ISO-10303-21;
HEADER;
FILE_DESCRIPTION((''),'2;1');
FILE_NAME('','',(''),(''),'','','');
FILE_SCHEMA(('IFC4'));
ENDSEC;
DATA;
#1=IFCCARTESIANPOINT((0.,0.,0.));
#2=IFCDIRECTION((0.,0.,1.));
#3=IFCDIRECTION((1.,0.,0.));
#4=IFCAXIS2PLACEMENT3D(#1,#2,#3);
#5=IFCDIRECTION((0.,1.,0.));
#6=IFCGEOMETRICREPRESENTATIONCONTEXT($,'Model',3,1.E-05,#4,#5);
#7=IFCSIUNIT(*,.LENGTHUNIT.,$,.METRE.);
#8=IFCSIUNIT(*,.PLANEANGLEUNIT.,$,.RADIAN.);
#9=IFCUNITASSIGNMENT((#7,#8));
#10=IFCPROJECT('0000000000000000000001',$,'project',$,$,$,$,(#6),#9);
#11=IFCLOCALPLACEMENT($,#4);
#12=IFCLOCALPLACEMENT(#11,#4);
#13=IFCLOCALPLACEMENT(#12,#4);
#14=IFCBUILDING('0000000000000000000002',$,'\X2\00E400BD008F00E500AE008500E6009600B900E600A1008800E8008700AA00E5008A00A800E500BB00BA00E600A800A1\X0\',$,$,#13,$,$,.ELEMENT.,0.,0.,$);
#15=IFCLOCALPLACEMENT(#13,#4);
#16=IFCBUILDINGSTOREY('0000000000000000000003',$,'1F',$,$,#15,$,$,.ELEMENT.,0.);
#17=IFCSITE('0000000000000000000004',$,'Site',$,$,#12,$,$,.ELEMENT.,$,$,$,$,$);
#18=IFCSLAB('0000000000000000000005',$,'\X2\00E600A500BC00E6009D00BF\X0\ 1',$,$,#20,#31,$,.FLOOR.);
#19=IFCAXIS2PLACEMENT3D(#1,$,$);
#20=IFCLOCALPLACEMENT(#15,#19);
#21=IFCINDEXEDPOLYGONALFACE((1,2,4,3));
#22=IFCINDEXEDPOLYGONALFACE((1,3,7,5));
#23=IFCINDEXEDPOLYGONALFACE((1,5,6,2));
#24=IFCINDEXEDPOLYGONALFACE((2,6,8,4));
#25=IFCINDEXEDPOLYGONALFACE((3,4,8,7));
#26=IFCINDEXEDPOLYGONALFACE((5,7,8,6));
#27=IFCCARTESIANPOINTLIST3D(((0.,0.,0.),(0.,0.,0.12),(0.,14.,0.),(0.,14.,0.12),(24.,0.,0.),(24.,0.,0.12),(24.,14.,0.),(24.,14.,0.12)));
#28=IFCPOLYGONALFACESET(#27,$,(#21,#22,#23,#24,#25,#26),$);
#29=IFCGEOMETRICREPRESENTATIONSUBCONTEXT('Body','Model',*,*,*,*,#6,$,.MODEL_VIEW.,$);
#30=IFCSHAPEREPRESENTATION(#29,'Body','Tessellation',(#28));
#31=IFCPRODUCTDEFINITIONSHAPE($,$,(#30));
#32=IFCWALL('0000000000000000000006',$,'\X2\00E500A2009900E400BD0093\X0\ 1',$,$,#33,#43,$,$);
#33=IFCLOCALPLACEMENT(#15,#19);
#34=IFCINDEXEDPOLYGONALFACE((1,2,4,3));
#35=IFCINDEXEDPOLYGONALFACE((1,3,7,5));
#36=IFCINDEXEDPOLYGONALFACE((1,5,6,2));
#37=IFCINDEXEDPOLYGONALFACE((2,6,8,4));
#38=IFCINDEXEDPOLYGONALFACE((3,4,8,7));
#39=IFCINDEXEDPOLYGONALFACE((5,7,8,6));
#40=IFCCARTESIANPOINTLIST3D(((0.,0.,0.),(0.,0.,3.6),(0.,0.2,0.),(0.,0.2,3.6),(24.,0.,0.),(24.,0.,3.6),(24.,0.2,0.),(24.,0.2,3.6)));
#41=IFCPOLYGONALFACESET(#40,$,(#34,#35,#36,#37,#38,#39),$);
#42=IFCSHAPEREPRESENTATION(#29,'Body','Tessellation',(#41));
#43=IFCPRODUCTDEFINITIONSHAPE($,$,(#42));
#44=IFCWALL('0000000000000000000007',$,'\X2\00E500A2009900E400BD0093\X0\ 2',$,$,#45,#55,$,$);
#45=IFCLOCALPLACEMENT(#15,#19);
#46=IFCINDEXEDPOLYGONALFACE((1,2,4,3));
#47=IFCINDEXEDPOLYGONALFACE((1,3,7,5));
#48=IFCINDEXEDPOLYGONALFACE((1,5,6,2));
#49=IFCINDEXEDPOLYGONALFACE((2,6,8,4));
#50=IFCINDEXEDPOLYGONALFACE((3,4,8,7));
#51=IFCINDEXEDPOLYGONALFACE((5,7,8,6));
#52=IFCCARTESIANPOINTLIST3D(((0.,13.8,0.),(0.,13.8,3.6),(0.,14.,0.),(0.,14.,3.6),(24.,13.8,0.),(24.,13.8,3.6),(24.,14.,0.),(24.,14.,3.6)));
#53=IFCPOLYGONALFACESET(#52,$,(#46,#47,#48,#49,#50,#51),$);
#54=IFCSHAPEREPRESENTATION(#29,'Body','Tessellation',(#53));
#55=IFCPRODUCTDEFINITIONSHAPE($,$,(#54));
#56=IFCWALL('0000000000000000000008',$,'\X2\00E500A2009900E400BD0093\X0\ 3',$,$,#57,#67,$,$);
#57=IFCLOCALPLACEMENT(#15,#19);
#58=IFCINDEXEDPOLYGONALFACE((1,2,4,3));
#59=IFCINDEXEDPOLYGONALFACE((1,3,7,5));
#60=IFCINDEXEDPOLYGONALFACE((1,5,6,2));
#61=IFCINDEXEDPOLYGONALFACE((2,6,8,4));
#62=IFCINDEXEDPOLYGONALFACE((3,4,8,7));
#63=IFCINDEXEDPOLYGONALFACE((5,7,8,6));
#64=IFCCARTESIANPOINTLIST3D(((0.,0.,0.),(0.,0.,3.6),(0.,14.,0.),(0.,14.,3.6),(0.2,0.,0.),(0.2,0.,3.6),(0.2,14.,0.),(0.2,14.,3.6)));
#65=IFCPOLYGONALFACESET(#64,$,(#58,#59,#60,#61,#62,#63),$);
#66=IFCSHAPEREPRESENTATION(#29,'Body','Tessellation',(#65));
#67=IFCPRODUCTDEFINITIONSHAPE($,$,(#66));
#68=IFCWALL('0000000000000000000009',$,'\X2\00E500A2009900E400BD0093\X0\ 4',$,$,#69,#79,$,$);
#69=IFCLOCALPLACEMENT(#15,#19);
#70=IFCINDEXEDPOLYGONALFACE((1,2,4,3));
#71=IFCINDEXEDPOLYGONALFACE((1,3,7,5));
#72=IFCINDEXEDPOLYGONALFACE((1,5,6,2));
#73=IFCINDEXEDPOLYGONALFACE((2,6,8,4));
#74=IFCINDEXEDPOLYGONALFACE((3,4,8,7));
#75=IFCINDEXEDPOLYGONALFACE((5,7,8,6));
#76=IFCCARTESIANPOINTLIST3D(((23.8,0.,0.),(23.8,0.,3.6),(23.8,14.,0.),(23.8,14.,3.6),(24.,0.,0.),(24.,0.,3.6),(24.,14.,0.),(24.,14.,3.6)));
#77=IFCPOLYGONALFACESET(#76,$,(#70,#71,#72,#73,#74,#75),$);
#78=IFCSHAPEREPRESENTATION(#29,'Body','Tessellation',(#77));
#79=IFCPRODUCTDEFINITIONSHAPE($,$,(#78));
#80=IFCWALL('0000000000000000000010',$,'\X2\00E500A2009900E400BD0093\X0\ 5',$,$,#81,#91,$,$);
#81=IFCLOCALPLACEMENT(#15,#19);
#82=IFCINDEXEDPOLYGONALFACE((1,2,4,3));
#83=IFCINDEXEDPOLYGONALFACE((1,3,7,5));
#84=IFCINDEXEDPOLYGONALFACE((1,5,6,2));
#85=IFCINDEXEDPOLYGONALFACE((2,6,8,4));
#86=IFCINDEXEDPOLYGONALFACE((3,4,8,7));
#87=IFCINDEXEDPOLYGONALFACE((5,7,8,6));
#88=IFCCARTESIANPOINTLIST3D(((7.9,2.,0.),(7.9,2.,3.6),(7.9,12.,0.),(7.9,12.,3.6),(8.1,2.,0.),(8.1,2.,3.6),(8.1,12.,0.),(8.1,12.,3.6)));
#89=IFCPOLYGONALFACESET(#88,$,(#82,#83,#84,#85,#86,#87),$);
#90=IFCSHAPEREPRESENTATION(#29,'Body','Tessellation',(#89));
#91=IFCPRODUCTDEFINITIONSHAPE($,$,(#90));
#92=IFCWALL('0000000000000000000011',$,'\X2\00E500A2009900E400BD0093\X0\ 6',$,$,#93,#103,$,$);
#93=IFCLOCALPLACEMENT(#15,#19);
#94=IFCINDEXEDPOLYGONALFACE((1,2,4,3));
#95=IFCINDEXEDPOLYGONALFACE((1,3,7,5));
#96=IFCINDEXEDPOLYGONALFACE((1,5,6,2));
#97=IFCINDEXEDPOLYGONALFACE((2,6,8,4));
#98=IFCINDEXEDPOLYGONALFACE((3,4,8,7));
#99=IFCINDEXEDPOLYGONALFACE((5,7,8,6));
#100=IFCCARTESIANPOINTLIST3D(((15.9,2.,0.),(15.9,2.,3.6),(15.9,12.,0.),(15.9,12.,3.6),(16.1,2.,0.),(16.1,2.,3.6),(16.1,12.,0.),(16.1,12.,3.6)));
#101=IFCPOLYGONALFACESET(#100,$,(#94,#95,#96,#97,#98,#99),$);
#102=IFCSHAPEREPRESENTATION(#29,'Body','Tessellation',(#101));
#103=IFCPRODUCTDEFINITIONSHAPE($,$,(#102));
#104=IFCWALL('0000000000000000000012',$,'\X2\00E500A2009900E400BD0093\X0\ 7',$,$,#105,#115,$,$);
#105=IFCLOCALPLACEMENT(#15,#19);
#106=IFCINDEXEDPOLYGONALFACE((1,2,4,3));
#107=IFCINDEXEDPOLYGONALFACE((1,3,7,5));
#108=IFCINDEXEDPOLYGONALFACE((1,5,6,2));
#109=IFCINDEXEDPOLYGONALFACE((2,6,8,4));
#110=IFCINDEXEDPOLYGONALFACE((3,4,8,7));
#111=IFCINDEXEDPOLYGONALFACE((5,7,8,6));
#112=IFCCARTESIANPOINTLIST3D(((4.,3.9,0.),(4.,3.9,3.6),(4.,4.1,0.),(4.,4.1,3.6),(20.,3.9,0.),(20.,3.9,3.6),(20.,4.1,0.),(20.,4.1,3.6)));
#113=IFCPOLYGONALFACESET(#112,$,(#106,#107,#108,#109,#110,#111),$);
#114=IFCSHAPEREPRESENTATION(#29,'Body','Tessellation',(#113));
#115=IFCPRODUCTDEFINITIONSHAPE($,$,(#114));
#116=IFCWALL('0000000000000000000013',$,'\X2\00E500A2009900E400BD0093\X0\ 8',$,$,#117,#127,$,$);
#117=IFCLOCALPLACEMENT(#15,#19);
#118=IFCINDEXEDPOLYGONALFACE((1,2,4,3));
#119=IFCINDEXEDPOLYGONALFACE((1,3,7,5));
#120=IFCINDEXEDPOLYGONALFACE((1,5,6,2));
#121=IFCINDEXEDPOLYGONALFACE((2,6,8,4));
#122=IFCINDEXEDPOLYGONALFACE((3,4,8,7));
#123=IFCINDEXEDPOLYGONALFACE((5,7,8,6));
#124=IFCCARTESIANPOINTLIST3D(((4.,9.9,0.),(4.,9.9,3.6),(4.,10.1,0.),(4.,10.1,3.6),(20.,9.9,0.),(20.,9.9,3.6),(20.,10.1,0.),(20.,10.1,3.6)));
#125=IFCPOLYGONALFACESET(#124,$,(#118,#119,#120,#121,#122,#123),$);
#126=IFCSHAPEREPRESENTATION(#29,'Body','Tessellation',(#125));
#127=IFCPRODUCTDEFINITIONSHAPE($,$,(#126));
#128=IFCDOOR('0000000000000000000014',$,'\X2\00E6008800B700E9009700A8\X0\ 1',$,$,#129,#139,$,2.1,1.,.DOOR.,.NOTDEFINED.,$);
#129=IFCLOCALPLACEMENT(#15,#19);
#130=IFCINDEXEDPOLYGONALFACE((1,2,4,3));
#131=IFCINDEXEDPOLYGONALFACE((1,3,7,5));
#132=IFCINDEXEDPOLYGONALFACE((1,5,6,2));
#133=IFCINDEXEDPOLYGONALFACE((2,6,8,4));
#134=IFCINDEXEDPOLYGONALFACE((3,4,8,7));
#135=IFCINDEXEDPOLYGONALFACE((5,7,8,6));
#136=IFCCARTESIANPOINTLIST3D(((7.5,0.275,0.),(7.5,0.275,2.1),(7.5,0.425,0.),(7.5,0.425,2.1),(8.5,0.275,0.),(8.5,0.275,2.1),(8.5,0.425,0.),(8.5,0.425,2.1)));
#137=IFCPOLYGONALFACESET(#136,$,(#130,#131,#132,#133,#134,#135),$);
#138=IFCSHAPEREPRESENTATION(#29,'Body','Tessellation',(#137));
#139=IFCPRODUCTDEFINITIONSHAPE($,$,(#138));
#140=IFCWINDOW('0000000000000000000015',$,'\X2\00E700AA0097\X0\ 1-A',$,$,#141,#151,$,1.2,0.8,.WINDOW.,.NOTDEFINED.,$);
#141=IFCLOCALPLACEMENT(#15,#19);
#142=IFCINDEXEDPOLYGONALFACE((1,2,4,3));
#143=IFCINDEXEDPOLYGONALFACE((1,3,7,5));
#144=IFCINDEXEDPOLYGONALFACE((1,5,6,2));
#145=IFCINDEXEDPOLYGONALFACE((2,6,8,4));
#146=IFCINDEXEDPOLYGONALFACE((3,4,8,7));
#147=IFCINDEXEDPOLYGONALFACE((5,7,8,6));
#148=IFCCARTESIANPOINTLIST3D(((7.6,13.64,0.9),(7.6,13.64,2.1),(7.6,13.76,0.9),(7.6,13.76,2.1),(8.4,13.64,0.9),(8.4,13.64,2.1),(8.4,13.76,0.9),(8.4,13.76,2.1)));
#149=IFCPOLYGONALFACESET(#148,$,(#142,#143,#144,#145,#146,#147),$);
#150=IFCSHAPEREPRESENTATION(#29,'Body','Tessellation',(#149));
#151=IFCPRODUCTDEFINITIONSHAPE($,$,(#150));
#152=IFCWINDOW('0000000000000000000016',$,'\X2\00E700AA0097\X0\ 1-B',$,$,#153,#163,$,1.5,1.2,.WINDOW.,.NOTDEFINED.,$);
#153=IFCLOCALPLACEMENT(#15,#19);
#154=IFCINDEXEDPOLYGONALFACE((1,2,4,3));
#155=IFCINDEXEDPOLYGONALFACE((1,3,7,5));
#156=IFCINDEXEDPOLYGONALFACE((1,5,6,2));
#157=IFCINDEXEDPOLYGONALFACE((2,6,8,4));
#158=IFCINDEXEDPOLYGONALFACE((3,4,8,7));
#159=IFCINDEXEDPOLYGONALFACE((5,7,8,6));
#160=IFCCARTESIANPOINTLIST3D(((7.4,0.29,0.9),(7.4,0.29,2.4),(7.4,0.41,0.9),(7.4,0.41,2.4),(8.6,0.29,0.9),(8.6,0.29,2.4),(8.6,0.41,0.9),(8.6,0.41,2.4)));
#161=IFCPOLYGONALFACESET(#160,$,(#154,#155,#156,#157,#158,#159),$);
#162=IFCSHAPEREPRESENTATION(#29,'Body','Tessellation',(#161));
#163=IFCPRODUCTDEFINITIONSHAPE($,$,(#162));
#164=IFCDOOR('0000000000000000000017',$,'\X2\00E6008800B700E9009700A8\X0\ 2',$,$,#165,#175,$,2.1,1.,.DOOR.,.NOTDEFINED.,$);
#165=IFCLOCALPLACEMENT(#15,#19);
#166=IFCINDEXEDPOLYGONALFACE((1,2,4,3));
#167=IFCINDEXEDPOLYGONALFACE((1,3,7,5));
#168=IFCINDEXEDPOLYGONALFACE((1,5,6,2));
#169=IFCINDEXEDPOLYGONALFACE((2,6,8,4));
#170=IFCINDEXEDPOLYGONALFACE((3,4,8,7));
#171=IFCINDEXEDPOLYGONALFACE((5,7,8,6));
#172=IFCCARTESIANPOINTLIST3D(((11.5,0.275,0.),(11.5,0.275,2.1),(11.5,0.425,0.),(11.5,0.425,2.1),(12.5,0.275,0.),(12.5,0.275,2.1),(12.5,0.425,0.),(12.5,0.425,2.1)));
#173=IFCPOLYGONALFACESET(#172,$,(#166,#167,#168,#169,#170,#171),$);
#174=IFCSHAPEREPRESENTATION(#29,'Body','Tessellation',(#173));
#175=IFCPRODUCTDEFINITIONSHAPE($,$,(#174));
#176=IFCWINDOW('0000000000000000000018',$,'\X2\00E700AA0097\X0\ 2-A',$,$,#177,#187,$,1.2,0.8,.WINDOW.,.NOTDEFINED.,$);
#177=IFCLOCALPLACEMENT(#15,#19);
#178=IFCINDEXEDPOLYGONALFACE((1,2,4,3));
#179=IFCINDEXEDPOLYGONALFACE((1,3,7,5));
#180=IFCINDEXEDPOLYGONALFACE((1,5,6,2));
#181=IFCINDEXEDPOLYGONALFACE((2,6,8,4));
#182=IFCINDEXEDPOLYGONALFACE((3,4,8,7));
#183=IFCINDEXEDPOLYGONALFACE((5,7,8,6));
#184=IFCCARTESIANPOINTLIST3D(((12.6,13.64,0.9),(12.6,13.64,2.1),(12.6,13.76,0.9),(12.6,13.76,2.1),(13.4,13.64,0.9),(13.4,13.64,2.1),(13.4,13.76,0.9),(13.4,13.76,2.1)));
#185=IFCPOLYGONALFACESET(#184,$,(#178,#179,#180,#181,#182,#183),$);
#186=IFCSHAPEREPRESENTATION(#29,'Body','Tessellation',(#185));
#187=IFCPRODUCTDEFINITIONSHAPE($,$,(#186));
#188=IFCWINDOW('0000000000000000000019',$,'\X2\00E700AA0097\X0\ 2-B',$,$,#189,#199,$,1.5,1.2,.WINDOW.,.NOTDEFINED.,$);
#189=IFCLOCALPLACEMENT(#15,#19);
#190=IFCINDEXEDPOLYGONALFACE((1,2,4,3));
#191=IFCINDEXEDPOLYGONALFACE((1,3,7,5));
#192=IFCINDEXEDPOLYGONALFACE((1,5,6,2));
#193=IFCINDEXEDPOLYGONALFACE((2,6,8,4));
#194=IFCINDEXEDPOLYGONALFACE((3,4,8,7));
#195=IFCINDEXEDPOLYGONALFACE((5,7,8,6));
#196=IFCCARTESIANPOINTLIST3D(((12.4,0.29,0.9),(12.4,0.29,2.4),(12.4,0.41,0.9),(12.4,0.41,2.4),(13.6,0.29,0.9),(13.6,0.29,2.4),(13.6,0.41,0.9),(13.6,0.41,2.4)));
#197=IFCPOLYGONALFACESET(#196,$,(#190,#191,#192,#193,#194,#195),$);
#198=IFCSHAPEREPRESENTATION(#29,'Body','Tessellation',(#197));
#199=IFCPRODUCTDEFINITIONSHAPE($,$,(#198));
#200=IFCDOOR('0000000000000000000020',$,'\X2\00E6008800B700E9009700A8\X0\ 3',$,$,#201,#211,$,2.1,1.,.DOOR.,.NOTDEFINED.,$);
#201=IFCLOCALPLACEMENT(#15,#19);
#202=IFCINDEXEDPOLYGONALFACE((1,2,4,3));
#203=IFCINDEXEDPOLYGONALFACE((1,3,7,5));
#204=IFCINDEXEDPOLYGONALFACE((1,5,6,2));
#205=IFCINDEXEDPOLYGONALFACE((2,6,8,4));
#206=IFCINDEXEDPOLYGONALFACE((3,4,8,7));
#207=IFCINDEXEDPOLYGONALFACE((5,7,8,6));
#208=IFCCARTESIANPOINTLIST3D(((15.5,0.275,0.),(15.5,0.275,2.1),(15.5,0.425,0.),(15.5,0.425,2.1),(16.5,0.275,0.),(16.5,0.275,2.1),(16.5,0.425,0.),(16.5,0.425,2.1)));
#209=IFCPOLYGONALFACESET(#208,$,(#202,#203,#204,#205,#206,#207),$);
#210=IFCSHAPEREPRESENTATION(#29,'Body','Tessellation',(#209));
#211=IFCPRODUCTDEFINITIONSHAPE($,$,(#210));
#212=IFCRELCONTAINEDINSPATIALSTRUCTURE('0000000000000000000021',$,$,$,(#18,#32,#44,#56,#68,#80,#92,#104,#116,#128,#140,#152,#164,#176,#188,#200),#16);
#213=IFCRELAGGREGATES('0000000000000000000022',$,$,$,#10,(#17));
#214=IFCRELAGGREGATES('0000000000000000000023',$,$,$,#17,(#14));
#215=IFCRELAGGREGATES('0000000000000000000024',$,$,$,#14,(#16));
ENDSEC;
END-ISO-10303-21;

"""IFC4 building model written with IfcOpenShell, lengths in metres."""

from ifc_helpers import new_model, si_unit, direction, frame, frame_2d, origin_with_axes, place, context, subcontext, project, spatial, rectangle, extrude, element, save


model = new_model("IFC4")

# Units and contexts
model_context = context("Model", 3, precision=1e-05, world=origin_with_axes(), true_north=direction((0.0, 1.0, 0.0)))
body_context = subcontext(model_context, "Body", "Model", "MODEL_VIEW")
ifc_project = project(units=[si_unit("LENGTHUNIT", "METRE"), si_unit("PLANEANGLEUNIT", "RADIAN")], contexts=[model_context])

# Site, building, storey
placement = place(None, origin_with_axes())
site_placement = place(placement, origin_with_axes())
site = spatial("IfcSite", under=ifc_project, at=site_placement, Name="Site", CompositionType="ELEMENT")
building_placement = place(site_placement, origin_with_axes())
building = spatial("IfcBuilding", under=site, at=building_placement, Name="ä½\u008få®\u0085æ\u0096¹æ¡\u0088è\u0087ªå\u008a¨å»ºæ¨¡", CompositionType="ELEMENT", ElevationOfRefHeight=0.0, ElevationOfTerrain=0.0)
storey_placement = place(building_placement, origin_with_axes())
storey = spatial("IfcBuildingStorey", under=building, at=storey_placement, Name="1F", CompositionType="ELEMENT", Elevation=0.0)

# Slab
slab_placement = place(storey_placement, frame((12.0, 7.0, 0.0), z_axis=(0.0, 0.0, 1.0), x_axis=(1.0, 0.0, 0.0)))
element("IfcSlab", 1, at=slab_placement, inside=storey, Name="æ¥¼æ\u009d¿ 1", PredefinedType="FLOOR", context=body_context, shape_type="SweptSolid", body=[
    extrude(rectangle(XDim=24.0, YDim=14.0, at=frame_2d((0.0, 0.0), x_axis=(1.0, 0.0, 0.0))), frame((0.0, 0.0, 0.0), z_axis=(0.0, 0.0, 1.0)), (0.0, 0.0, 1.0), 0.12),
])

# Walls
for number, where, z_axis, x_axis, name in (
    (2, (12.0, 0.1, 0.0), (0.0, 0.0, 1.0), (1.0, 0.0, 0.0), "å¢\u0099ä½\u0093 1"),
    (3, (12.0, 13.9, 0.0), (0.0, 0.0, 1.0), (1.0, 0.0, 0.0), "å¢\u0099ä½\u0093 2"),
):
    element("IfcWall", number, at=place(storey_placement, frame(where, z_axis=z_axis, x_axis=x_axis)), inside=storey, Name=name, context=body_context, shape_type="SweptSolid", body=[
        extrude(rectangle(XDim=24.0, YDim=0.2, at=frame_2d((0.0, 0.0), x_axis=(1.0, 0.0, 0.0))), frame((0.0, 0.0, 0.0), z_axis=(0.0, 0.0, 1.0)), (0.0, 0.0, 1.0), 3.6),
    ])
for number, where, z_axis, x_axis, name in (
    (4, (0.1, 7.0, 0.0), (0.0, 0.0, 1.0), (0.0, 1.0, 0.0), "å¢\u0099ä½\u0093 3"),
    (5, (23.9, 7.0, 0.0), (0.0, 0.0, 1.0), (0.0, 1.0, 0.0), "å¢\u0099ä½\u0093 4"),
):
    element("IfcWall", number, at=place(storey_placement, frame(where, z_axis=z_axis, x_axis=x_axis)), inside=storey, Name=name, context=body_context, shape_type="SweptSolid", body=[
        extrude(rectangle(XDim=14.0, YDim=0.2, at=frame_2d((0.0, 0.0), x_axis=(1.0, 0.0, 0.0))), frame((0.0, 0.0, 0.0), z_axis=(0.0, 0.0, 1.0)), (0.0, 0.0, 1.0), 3.6),
    ])
for number, where, z_axis, x_axis, name in (
    (6, (8.0, 7.0, 0.0), (0.0, 0.0, 1.0), (0.0, 1.0, 0.0), "å¢\u0099ä½\u0093 5"),
    (7, (16.0, 7.0, 0.0), (0.0, 0.0, 1.0), (0.0, 1.0, 0.0), "å¢\u0099ä½\u0093 6"),
):
    element("IfcWall", number, at=place(storey_placement, frame(where, z_axis=z_axis, x_axis=x_axis)), inside=storey, Name=name, context=body_context, shape_type="SweptSolid", body=[
        extrude(rectangle(XDim=10.0, YDim=0.2, at=frame_2d((0.0, 0.0), x_axis=(1.0, 0.0, 0.0))), frame((0.0, 0.0, 0.0), z_axis=(0.0, 0.0, 1.0)), (0.0, 0.0, 1.0), 3.6),
    ])
for number, where, z_axis, x_axis, name in (
    (8, (12.0, 4.0, 0.0), (0.0, 0.0, 1.0), (1.0, 0.0, 0.0), "å¢\u0099ä½\u0093 7"),
    (9, (12.0, 10.0, 0.0), (0.0, 0.0, 1.0), (1.0, 0.0, 0.0), "å¢\u0099ä½\u0093 8"),
):
    element("IfcWall", number, at=place(storey_placement, frame(where, z_axis=z_axis, x_axis=x_axis)), inside=storey, Name=name, context=body_context, shape_type="SweptSolid", body=[
        extrude(rectangle(XDim=16.0, YDim=0.2, at=frame_2d((0.0, 0.0), x_axis=(1.0, 0.0, 0.0))), frame((0.0, 0.0, 0.0), z_axis=(0.0, 0.0, 1.0)), (0.0, 0.0, 1.0), 3.6),
    ])

# Door
door_1_placement = place(storey_placement, frame((8.0, 0.35, 0.0), z_axis=(0.0, 0.0, 1.0), x_axis=(1.0, 0.0, 0.0)))
element("IfcDoor", 10, at=door_1_placement, inside=storey, Name="æ\u0088·é\u0097¨ 1", OperationType="NOTDEFINED", OverallHeight=2.1, OverallWidth=1.0, PredefinedType="DOOR", context=body_context, shape_type="SweptSolid", body=[
    extrude(rectangle(XDim=1.0, YDim=0.15, at=frame_2d((0.0, 0.0), x_axis=(1.0, 0.0, 0.0))), frame((0.0, 0.0, 0.0), z_axis=(0.0, 0.0, 1.0)), (0.0, 0.0, 1.0), 2.1),
])

# Windows
window_1_placement = place(storey_placement, frame((8.0, 13.7, 0.9), z_axis=(0.0, 0.0, 1.0), x_axis=(1.0, 0.0, 0.0)))
element("IfcWindow", 11, at=window_1_placement, inside=storey, Name="çª\u0097 1-A", OverallHeight=1.2, OverallWidth=0.8, PartitioningType="NOTDEFINED", PredefinedType="WINDOW", context=body_context, shape_type="SweptSolid", body=[
    extrude(rectangle(XDim=0.8, YDim=0.12, at=frame_2d((0.0, 0.0), x_axis=(1.0, 0.0, 0.0))), frame((0.0, 0.0, 0.0), z_axis=(0.0, 0.0, 1.0)), (0.0, 0.0, 1.0), 1.2),
])
window_2_placement = place(storey_placement, frame((8.0, 0.35, 0.9), z_axis=(0.0, 0.0, 1.0), x_axis=(1.0, 0.0, 0.0)))
element("IfcWindow", 12, at=window_2_placement, inside=storey, Name="çª\u0097 1-B", OverallHeight=1.5, OverallWidth=1.2, PartitioningType="NOTDEFINED", PredefinedType="WINDOW", context=body_context, shape_type="SweptSolid", body=[
    extrude(rectangle(XDim=1.2, YDim=0.12, at=frame_2d((0.0, 0.0), x_axis=(1.0, 0.0, 0.0))), frame((0.0, 0.0, 0.0), z_axis=(0.0, 0.0, 1.0)), (0.0, 0.0, 1.0), 1.5),
])

# Door
door_2_placement = place(storey_placement, frame((12.0, 0.35, 0.0), z_axis=(0.0, 0.0, 1.0), x_axis=(1.0, 0.0, 0.0)))
element("IfcDoor", 13, at=door_2_placement, inside=storey, Name="æ\u0088·é\u0097¨ 2", OperationType="NOTDEFINED", OverallHeight=2.1, OverallWidth=1.0, PredefinedType="DOOR", context=body_context, shape_type="SweptSolid", body=[
    extrude(rectangle(XDim=1.0, YDim=0.15, at=frame_2d((0.0, 0.0), x_axis=(1.0, 0.0, 0.0))), frame((0.0, 0.0, 0.0), z_axis=(0.0, 0.0, 1.0)), (0.0, 0.0, 1.0), 2.1),
])

# Windows
window_3_placement = place(storey_placement, frame((13.0, 13.7, 0.9), z_axis=(0.0, 0.0, 1.0), x_axis=(1.0, 0.0, 0.0)))
element("IfcWindow", 14, at=window_3_placement, inside=storey, Name="çª\u0097 2-A", OverallHeight=1.2, OverallWidth=0.8, PartitioningType="NOTDEFINED", PredefinedType="WINDOW", context=body_context, shape_type="SweptSolid", body=[
    extrude(rectangle(XDim=0.8, YDim=0.12, at=frame_2d((0.0, 0.0), x_axis=(1.0, 0.0, 0.0))), frame((0.0, 0.0, 0.0), z_axis=(0.0, 0.0, 1.0)), (0.0, 0.0, 1.0), 1.2),
])
window_4_placement = place(storey_placement, frame((13.0, 0.35, 0.9), z_axis=(0.0, 0.0, 1.0), x_axis=(1.0, 0.0, 0.0)))
element("IfcWindow", 15, at=window_4_placement, inside=storey, Name="çª\u0097 2-B", OverallHeight=1.5, OverallWidth=1.2, PartitioningType="NOTDEFINED", PredefinedType="WINDOW", context=body_context, shape_type="SweptSolid", body=[
    extrude(rectangle(XDim=1.2, YDim=0.12, at=frame_2d((0.0, 0.0), x_axis=(1.0, 0.0, 0.0))), frame((0.0, 0.0, 0.0), z_axis=(0.0, 0.0, 1.0)), (0.0, 0.0, 1.0), 1.5),
])

# Door
door_3_placement = place(storey_placement, frame((16.0, 0.35, 0.0), z_axis=(0.0, 0.0, 1.0), x_axis=(1.0, 0.0, 0.0)))
element("IfcDoor", 16, at=door_3_placement, inside=storey, Name="æ\u0088·é\u0097¨ 3", OperationType="NOTDEFINED", OverallHeight=2.1, OverallWidth=1.0, PredefinedType="DOOR", context=body_context, shape_type="SweptSolid", body=[
    extrude(rectangle(XDim=1.0, YDim=0.15, at=frame_2d((0.0, 0.0), x_axis=(1.0, 0.0, 0.0))), frame((0.0, 0.0, 0.0), z_axis=(0.0, 0.0, 1.0)), (0.0, 0.0, 1.0), 2.1),
])

save(model, "model.ifc")
